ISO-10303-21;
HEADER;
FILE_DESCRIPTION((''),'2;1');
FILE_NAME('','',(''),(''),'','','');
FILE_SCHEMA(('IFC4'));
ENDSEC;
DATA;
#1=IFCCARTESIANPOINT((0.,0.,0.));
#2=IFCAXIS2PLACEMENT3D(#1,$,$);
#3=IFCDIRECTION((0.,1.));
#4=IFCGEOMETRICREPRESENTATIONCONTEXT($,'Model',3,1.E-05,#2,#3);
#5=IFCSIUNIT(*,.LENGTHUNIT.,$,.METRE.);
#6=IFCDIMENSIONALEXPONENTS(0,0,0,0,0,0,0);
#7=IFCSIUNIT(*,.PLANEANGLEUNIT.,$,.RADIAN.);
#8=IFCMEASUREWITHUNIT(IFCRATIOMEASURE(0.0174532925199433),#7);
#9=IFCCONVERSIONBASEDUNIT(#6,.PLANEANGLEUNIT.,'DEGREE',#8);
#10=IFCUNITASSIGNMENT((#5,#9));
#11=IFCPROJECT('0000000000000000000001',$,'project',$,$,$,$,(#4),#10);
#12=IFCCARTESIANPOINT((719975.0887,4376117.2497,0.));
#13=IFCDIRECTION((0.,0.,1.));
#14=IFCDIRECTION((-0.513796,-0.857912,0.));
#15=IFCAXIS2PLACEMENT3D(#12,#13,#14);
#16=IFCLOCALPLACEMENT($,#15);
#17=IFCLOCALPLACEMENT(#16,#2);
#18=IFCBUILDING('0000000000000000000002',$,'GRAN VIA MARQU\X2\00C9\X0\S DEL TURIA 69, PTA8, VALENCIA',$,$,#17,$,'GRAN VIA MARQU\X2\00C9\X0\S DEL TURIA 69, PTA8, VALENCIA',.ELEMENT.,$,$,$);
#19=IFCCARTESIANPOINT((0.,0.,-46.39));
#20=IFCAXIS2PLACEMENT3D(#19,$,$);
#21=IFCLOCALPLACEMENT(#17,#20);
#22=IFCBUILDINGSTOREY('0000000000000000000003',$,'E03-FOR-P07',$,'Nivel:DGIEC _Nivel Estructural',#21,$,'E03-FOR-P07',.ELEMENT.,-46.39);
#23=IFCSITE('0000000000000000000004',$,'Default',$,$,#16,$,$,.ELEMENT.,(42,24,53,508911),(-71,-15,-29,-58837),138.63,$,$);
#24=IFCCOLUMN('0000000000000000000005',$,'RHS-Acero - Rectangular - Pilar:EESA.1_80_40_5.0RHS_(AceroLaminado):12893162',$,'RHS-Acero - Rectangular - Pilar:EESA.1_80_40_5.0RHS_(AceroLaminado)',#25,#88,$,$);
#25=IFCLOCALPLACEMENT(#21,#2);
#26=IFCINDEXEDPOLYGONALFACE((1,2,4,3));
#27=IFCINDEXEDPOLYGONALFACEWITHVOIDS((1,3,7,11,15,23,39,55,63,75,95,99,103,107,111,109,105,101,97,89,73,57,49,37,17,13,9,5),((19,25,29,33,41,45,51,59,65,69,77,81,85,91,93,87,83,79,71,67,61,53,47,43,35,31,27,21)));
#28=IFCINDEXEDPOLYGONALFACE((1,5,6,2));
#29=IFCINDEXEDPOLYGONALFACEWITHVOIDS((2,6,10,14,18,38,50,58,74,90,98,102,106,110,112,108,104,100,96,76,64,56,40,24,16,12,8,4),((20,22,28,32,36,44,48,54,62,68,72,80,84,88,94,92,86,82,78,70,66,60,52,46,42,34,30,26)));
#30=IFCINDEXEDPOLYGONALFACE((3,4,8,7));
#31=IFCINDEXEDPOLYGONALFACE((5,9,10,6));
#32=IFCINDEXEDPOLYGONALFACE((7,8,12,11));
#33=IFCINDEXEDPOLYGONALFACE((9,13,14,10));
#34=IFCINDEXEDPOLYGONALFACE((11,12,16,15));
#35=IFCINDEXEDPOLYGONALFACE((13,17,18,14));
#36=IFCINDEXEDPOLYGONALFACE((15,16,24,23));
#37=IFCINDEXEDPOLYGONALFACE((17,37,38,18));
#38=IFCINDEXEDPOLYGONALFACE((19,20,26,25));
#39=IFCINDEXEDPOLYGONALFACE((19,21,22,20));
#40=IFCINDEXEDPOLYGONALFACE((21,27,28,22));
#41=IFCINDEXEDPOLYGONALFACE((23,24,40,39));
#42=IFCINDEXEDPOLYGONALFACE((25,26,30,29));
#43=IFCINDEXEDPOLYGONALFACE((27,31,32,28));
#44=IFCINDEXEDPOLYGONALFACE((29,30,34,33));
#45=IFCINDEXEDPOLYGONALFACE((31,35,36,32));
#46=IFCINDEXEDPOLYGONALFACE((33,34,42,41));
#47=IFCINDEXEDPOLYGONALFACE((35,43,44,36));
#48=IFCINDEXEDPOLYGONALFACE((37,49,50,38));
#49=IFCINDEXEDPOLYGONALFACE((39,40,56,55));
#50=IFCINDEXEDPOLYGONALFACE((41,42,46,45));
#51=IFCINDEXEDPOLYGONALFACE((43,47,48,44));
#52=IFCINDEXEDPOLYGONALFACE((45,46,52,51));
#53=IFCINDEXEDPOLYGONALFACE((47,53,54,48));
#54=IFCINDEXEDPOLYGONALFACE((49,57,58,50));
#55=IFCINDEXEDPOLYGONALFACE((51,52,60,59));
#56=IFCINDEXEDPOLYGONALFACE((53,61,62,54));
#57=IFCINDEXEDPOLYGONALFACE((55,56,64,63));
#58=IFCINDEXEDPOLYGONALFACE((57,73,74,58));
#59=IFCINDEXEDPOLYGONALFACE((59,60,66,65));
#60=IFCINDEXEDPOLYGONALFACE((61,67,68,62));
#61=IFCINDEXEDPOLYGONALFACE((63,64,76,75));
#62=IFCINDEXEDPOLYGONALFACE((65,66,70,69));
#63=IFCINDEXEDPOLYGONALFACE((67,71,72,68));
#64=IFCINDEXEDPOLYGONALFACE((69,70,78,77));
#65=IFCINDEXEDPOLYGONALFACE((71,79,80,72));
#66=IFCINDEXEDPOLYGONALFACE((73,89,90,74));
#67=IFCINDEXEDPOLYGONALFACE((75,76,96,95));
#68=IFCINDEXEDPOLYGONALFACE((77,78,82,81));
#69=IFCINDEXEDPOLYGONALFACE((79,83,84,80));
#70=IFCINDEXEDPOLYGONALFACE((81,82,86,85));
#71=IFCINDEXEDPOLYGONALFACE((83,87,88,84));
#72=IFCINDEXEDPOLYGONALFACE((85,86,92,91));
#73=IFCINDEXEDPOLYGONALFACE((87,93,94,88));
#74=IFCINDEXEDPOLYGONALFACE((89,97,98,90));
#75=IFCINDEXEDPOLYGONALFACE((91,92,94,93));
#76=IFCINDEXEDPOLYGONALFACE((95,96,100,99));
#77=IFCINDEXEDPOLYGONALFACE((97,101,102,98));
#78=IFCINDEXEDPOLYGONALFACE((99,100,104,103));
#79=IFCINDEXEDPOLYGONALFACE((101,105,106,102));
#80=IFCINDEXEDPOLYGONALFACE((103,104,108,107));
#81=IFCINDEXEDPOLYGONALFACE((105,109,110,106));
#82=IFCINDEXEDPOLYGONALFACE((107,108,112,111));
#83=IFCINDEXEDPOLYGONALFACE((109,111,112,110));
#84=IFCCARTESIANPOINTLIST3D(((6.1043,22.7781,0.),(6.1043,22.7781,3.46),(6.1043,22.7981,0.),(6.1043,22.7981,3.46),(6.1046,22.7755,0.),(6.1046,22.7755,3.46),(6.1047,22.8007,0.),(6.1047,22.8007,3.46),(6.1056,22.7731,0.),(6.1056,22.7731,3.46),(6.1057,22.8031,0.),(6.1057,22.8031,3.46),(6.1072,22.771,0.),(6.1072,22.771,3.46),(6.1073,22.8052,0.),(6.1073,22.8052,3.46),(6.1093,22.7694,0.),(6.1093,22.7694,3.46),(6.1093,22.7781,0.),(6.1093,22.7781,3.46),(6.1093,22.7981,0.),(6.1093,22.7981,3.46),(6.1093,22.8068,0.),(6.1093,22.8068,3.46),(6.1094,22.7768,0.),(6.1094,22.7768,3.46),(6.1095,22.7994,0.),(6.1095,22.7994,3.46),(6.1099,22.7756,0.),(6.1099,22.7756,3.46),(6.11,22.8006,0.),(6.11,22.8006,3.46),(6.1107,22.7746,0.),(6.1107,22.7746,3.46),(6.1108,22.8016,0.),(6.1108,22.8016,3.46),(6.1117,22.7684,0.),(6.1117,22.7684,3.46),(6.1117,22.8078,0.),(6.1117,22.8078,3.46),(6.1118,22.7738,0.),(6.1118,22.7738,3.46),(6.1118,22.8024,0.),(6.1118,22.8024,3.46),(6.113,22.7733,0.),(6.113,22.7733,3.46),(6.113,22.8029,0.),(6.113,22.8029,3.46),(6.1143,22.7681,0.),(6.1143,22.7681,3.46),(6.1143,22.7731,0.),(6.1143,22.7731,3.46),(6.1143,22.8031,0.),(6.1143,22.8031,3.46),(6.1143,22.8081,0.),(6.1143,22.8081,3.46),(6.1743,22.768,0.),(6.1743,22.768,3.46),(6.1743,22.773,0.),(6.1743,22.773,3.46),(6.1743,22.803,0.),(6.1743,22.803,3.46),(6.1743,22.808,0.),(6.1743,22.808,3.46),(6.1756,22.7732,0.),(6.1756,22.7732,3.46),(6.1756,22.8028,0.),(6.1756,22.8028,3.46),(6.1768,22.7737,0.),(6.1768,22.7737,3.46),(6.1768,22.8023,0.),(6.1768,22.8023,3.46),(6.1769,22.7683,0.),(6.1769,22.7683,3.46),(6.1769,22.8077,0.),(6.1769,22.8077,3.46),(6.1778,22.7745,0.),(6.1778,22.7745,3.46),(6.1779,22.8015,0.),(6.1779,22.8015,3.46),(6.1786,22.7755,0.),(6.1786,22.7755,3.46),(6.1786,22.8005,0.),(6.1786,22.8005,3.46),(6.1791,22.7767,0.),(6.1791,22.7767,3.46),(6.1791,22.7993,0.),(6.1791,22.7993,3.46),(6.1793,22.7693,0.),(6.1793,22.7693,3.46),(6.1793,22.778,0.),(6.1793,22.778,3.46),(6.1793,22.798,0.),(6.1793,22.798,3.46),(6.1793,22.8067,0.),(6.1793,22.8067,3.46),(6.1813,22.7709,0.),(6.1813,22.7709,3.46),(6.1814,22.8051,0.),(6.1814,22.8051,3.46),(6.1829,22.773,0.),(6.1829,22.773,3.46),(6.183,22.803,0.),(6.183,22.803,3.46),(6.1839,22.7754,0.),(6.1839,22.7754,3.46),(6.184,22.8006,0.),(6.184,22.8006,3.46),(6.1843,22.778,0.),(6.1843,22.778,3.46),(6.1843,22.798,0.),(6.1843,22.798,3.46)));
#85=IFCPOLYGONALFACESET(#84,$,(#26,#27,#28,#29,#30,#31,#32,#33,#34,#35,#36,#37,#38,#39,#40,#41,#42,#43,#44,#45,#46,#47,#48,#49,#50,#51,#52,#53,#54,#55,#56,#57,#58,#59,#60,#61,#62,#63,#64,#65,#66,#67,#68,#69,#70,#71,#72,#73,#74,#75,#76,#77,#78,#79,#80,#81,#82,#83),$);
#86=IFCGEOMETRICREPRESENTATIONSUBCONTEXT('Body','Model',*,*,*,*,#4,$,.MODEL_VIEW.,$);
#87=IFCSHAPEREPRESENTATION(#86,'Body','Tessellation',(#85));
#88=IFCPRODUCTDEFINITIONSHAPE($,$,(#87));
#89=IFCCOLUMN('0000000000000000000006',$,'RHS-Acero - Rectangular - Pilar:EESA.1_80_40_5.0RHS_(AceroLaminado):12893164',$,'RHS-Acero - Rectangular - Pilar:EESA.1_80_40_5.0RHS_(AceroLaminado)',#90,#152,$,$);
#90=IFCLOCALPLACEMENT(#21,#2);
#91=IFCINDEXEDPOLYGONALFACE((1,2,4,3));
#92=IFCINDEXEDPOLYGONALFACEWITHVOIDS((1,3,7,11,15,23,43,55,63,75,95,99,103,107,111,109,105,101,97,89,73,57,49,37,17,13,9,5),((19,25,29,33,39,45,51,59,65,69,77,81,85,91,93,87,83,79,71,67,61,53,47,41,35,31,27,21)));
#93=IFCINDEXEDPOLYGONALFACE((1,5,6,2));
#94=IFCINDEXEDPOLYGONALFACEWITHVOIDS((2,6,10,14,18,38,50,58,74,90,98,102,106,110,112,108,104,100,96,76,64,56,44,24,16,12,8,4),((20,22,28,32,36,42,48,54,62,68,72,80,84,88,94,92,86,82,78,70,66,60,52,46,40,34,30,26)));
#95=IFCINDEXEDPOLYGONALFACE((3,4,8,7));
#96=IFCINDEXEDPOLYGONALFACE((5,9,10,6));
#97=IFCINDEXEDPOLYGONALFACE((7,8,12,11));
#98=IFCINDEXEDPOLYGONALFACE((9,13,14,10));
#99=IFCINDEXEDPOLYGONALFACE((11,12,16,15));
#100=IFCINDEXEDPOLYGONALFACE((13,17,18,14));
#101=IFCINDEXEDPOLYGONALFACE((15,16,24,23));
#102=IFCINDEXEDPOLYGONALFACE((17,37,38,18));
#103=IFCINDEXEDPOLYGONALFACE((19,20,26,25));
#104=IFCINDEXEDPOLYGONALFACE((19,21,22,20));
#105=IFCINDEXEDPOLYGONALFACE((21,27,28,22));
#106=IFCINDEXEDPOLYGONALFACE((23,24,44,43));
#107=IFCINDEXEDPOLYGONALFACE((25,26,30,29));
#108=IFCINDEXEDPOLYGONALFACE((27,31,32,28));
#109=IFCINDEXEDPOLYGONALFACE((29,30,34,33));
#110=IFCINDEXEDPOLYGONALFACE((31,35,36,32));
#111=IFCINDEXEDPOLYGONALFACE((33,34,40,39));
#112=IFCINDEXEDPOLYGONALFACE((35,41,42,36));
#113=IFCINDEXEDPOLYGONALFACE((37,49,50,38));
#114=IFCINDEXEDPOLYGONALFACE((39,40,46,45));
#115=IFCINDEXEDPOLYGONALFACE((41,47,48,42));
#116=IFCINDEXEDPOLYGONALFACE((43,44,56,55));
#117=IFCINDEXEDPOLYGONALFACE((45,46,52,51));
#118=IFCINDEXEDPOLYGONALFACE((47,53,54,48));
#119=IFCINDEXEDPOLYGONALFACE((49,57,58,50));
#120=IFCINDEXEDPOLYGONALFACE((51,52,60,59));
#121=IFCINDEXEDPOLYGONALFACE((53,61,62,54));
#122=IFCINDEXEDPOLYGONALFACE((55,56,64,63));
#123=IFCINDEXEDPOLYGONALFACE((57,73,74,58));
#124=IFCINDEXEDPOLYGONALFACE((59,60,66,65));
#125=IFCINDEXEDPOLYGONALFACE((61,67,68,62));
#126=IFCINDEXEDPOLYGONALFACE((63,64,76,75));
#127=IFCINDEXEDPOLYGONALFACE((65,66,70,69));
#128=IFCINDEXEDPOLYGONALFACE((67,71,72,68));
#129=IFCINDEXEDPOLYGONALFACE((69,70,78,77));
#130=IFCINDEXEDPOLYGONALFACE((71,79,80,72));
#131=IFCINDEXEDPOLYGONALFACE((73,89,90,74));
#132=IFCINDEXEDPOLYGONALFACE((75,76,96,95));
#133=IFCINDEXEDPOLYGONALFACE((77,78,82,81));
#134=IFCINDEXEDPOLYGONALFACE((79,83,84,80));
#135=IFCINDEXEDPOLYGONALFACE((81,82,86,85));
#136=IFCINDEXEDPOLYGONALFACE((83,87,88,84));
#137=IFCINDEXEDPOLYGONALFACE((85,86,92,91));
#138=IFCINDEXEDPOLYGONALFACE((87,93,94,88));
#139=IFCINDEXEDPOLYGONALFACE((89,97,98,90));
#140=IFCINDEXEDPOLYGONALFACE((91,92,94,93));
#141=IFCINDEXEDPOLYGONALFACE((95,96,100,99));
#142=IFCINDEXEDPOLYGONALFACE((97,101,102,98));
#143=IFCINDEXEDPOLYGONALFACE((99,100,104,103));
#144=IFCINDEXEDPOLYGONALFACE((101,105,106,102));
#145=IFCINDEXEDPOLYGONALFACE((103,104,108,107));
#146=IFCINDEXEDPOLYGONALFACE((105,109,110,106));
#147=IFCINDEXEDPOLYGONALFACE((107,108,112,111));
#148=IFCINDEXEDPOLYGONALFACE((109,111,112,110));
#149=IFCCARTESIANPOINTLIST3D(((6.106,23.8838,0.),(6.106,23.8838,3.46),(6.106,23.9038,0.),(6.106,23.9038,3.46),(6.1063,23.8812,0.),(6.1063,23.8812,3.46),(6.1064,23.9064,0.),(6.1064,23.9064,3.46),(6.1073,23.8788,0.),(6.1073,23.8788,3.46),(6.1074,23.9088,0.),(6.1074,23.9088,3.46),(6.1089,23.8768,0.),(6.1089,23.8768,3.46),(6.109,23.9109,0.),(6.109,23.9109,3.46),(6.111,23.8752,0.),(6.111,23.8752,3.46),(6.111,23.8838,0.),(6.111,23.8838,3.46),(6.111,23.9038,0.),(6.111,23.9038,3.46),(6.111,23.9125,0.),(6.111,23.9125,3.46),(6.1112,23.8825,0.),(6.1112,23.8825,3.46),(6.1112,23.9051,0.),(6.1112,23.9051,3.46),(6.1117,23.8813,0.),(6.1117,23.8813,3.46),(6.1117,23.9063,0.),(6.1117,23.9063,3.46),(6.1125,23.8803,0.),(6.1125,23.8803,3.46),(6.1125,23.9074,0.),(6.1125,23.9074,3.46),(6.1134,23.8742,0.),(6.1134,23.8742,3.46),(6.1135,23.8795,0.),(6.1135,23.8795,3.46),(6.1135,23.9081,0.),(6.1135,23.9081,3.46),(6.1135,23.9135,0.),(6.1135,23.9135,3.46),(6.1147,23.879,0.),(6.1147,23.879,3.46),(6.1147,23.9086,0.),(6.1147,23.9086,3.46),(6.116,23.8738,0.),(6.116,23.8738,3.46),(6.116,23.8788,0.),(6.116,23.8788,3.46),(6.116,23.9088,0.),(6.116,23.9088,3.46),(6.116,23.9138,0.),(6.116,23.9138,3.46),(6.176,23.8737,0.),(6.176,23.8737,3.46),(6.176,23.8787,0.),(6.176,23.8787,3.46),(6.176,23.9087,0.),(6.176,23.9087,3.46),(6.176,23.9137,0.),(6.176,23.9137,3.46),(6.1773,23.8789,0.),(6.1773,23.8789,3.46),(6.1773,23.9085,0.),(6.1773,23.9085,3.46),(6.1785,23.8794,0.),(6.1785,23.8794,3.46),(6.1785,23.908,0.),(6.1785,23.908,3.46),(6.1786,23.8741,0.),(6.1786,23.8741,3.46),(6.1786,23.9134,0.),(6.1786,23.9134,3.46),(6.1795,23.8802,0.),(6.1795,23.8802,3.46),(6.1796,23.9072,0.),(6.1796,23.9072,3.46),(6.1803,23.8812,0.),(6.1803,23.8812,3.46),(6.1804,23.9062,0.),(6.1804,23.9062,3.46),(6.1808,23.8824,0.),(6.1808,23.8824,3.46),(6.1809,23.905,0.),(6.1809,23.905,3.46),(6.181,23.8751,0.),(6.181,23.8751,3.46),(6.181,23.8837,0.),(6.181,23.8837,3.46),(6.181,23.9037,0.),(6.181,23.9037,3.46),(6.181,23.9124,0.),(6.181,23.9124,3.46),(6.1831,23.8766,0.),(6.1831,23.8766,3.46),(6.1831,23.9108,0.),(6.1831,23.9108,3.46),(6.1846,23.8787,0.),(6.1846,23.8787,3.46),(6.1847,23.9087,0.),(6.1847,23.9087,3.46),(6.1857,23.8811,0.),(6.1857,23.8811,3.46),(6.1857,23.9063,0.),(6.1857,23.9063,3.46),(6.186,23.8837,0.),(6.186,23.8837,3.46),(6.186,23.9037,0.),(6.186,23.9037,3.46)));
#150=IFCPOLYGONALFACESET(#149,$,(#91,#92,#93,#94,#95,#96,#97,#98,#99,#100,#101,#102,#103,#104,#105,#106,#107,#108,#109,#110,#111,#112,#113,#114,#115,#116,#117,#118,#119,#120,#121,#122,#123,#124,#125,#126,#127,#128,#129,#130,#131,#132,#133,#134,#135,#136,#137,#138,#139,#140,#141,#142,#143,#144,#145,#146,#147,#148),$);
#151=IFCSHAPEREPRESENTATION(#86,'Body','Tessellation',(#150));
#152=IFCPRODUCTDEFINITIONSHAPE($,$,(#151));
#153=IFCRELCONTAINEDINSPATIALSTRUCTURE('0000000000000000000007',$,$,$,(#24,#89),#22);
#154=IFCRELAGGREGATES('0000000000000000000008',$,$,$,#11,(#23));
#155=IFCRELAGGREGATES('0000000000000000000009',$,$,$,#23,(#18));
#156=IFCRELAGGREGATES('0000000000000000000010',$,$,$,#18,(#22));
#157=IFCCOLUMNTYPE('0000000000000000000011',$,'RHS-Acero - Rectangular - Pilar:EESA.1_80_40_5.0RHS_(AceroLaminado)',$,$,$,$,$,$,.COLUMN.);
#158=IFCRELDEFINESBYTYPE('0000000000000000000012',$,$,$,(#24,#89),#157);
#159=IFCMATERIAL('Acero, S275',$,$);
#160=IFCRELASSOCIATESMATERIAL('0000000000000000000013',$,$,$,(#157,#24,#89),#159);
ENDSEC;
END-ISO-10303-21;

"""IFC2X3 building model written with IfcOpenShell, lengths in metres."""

from ifc_helpers import new_model, entity, si_unit, converted_unit, direction, frame, frame_2d, origin, place, context, subcontext, project, spatial, polyline, circle_curve, parameter, trimmed, segment, composite_curve, outline, extrude, source, transform, mapped, material, type_object, type_shapes, element, save


model = new_model("IFC2X3")

# Units and contexts
model_context = context("Model", 3, precision=1e-05, world=origin(), true_north=direction((0.0, 1.0)))
body_context = subcontext(model_context, "Body", "Model", "MODEL_VIEW")
ifc_project = project(units=[si_unit("LENGTHUNIT", "METRE"), converted_unit("PLANEANGLEUNIT", "DEGREE", entity("IfcRatioMeasure", 0.0174532925199433), si_unit("PLANEANGLEUNIT", "RADIAN"), dimensions=[0, 0, 0, 0, 0, 0, 0])], contexts=[model_context])

# Site, building, storey
site_placement = place(None, frame((719975.0887, 4376117.2497, 0.0), z_axis=(0.0, 0.0, 1.0), x_axis=(-0.513796, -0.857912, 0.0)))
site = spatial("IfcSite", under=ifc_project, at=site_placement, Name="Default", CompositionType="ELEMENT", RefLatitude=(42, 24, 53, 508911), RefLongitude=(-71, -15, -29, -58837), RefElevation=138.63)
building_placement = place(site_placement, origin())
building = spatial("IfcBuilding", under=site, at=building_placement, Name="GRAN VIA MARQUÉS DEL TURIA 69, PTA8, VALENCIA", LongName="GRAN VIA MARQUÉS DEL TURIA 69, PTA8, VALENCIA", CompositionType="ELEMENT")
storey_placement = place(building_placement, frame((0.0, 0.0, -46.39)))
storey = spatial("IfcBuildingStorey", under=building, at=storey_placement, Name="E03-FOR-P07", ObjectType="Nivel:DGIEC _Nivel Estructural", LongName="E03-FOR-P07", CompositionType="ELEMENT", Elevation=-46.39)

# Columns
ifc_material = material(Name="Acero, S275")
column_type_1 = type_object("IfcColumnType", Name="RHS-Acero - Rectangular - Pilar:EESA.1_80_40_5.0RHS_(AceroLaminado)", PredefinedType="COLUMN", material=ifc_material)
shared_shape_1 = source(origin(), body_context, "Body", "SweptSolid", [
    extrude(outline(composite_curve([segment(polyline([(-0.01, -0.04), (0.01, -0.04)]), True, "CONTINUOUS"), segment(trimmed(circle_curve(frame_2d((0.01, -0.03), x_axis=(-1.0, 0.0)), 0.01), [parameter(90.0)], [parameter(180.0)], True, "PARAMETER"), True, "CONTINUOUS"), segment(polyline([(0.02, -0.03), (0.02, 0.03)]), True, "CONTINUOUS"), segment(trimmed(circle_curve(frame_2d((0.01, 0.03), x_axis=(-1.0, 0.0)), 0.01), [parameter(180.0)], [parameter(270.0)], True, "PARAMETER"), True, "CONTINUOUS"), segment(polyline([(0.01, 0.04), (-0.01, 0.04)]), True, "CONTINUOUS"), segment(trimmed(circle_curve(frame_2d((-0.01, 0.03), x_axis=(-1.0, 0.0)), 0.01), [parameter(270.0)], [parameter(360.0)], True, "PARAMETER"), True, "CONTINUOUS"), segment(polyline([(-0.02, 0.03), (-0.02, -0.03)]), True, "CONTINUOUS"), segment(trimmed(circle_curve(frame_2d((-0.01, -0.03), x_axis=(-1.0, 0.0)), 0.01), [parameter(360.0)], [parameter(90.0)], True, "PARAMETER"), True, "CONTINUOUS")], self_intersect=False), holes=[composite_curve([segment(trimmed(circle_curve(frame_2d((-0.01, -0.03), x_axis=(-1.0, 0.0)), 0.005), [parameter(0.0)], [parameter(90.0)], True, "PARAMETER"), False, "CONTINUOUS"), segment(polyline([(-0.015, -0.03), (-0.015, 0.03)]), True, "CONTINUOUS"), segment(trimmed(circle_curve(frame_2d((-0.01, 0.03), x_axis=(-1.0, 0.0)), 0.005), [parameter(270.0)], [parameter(0.0)], True, "PARAMETER"), False, "CONTINUOUS"), segment(polyline([(-0.01, 0.035), (0.01, 0.035)]), True, "CONTINUOUS"), segment(trimmed(circle_curve(frame_2d((0.01, 0.03), x_axis=(-1.0, 0.0)), 0.005), [parameter(180.0)], [parameter(270.0)], True, "PARAMETER"), False, "CONTINUOUS"), segment(polyline([(0.015, 0.03), (0.015, -0.03)]), True, "CONTINUOUS"), segment(trimmed(circle_curve(frame_2d((0.01, -0.03), x_axis=(-1.0, 0.0)), 0.005), [parameter(90.0)], [parameter(180.0)], True, "PARAMETER"), False, "CONTINUOUS"), segment(polyline([(0.01, -0.035), (-0.01, -0.035)]), True, "CONTINUOUS")], self_intersect=False)]), frame((0.0, 0.0, -46.39), z_axis=(0.0, 0.0, 1.0), x_axis=(-1.0, 0.0, 0.0)), (0.0, 0.0, 1.0), 3.46),
])
type_shapes(column_type_1, [shared_shape_1])
for number, where, z_axis, x_axis, name in (
    (1, (6.1443, 22.7881, 46.39), (0.0, 0.0, 1.0), (0.001552, 0.999999, 0.0), "RHS-Acero - Rectangular - Pilar:EESA.1_80_40_5.0RHS_(AceroLaminado):12893162"),
    (2, (6.146, 23.8938, 46.39), (0.0, 0.0, 1.0), (0.001552, 0.999999, 0.0), "RHS-Acero - Rectangular - Pilar:EESA.1_80_40_5.0RHS_(AceroLaminado):12893164"),
):
    element("IfcColumn", number, at=place(storey_placement, frame(where, z_axis=z_axis, x_axis=x_axis)), inside=storey, type_object=column_type_1, material=ifc_material, Name=name, ObjectType="RHS-Acero - Rectangular - Pilar:EESA.1_80_40_5.0RHS_(AceroLaminado)", context=body_context, shape_type="MappedRepresentation", body=[
        mapped(shared_shape_1, transform((0.0, 0.0, 0.0), scale=1.0)),
    ])

save(model, "model.ifc")
